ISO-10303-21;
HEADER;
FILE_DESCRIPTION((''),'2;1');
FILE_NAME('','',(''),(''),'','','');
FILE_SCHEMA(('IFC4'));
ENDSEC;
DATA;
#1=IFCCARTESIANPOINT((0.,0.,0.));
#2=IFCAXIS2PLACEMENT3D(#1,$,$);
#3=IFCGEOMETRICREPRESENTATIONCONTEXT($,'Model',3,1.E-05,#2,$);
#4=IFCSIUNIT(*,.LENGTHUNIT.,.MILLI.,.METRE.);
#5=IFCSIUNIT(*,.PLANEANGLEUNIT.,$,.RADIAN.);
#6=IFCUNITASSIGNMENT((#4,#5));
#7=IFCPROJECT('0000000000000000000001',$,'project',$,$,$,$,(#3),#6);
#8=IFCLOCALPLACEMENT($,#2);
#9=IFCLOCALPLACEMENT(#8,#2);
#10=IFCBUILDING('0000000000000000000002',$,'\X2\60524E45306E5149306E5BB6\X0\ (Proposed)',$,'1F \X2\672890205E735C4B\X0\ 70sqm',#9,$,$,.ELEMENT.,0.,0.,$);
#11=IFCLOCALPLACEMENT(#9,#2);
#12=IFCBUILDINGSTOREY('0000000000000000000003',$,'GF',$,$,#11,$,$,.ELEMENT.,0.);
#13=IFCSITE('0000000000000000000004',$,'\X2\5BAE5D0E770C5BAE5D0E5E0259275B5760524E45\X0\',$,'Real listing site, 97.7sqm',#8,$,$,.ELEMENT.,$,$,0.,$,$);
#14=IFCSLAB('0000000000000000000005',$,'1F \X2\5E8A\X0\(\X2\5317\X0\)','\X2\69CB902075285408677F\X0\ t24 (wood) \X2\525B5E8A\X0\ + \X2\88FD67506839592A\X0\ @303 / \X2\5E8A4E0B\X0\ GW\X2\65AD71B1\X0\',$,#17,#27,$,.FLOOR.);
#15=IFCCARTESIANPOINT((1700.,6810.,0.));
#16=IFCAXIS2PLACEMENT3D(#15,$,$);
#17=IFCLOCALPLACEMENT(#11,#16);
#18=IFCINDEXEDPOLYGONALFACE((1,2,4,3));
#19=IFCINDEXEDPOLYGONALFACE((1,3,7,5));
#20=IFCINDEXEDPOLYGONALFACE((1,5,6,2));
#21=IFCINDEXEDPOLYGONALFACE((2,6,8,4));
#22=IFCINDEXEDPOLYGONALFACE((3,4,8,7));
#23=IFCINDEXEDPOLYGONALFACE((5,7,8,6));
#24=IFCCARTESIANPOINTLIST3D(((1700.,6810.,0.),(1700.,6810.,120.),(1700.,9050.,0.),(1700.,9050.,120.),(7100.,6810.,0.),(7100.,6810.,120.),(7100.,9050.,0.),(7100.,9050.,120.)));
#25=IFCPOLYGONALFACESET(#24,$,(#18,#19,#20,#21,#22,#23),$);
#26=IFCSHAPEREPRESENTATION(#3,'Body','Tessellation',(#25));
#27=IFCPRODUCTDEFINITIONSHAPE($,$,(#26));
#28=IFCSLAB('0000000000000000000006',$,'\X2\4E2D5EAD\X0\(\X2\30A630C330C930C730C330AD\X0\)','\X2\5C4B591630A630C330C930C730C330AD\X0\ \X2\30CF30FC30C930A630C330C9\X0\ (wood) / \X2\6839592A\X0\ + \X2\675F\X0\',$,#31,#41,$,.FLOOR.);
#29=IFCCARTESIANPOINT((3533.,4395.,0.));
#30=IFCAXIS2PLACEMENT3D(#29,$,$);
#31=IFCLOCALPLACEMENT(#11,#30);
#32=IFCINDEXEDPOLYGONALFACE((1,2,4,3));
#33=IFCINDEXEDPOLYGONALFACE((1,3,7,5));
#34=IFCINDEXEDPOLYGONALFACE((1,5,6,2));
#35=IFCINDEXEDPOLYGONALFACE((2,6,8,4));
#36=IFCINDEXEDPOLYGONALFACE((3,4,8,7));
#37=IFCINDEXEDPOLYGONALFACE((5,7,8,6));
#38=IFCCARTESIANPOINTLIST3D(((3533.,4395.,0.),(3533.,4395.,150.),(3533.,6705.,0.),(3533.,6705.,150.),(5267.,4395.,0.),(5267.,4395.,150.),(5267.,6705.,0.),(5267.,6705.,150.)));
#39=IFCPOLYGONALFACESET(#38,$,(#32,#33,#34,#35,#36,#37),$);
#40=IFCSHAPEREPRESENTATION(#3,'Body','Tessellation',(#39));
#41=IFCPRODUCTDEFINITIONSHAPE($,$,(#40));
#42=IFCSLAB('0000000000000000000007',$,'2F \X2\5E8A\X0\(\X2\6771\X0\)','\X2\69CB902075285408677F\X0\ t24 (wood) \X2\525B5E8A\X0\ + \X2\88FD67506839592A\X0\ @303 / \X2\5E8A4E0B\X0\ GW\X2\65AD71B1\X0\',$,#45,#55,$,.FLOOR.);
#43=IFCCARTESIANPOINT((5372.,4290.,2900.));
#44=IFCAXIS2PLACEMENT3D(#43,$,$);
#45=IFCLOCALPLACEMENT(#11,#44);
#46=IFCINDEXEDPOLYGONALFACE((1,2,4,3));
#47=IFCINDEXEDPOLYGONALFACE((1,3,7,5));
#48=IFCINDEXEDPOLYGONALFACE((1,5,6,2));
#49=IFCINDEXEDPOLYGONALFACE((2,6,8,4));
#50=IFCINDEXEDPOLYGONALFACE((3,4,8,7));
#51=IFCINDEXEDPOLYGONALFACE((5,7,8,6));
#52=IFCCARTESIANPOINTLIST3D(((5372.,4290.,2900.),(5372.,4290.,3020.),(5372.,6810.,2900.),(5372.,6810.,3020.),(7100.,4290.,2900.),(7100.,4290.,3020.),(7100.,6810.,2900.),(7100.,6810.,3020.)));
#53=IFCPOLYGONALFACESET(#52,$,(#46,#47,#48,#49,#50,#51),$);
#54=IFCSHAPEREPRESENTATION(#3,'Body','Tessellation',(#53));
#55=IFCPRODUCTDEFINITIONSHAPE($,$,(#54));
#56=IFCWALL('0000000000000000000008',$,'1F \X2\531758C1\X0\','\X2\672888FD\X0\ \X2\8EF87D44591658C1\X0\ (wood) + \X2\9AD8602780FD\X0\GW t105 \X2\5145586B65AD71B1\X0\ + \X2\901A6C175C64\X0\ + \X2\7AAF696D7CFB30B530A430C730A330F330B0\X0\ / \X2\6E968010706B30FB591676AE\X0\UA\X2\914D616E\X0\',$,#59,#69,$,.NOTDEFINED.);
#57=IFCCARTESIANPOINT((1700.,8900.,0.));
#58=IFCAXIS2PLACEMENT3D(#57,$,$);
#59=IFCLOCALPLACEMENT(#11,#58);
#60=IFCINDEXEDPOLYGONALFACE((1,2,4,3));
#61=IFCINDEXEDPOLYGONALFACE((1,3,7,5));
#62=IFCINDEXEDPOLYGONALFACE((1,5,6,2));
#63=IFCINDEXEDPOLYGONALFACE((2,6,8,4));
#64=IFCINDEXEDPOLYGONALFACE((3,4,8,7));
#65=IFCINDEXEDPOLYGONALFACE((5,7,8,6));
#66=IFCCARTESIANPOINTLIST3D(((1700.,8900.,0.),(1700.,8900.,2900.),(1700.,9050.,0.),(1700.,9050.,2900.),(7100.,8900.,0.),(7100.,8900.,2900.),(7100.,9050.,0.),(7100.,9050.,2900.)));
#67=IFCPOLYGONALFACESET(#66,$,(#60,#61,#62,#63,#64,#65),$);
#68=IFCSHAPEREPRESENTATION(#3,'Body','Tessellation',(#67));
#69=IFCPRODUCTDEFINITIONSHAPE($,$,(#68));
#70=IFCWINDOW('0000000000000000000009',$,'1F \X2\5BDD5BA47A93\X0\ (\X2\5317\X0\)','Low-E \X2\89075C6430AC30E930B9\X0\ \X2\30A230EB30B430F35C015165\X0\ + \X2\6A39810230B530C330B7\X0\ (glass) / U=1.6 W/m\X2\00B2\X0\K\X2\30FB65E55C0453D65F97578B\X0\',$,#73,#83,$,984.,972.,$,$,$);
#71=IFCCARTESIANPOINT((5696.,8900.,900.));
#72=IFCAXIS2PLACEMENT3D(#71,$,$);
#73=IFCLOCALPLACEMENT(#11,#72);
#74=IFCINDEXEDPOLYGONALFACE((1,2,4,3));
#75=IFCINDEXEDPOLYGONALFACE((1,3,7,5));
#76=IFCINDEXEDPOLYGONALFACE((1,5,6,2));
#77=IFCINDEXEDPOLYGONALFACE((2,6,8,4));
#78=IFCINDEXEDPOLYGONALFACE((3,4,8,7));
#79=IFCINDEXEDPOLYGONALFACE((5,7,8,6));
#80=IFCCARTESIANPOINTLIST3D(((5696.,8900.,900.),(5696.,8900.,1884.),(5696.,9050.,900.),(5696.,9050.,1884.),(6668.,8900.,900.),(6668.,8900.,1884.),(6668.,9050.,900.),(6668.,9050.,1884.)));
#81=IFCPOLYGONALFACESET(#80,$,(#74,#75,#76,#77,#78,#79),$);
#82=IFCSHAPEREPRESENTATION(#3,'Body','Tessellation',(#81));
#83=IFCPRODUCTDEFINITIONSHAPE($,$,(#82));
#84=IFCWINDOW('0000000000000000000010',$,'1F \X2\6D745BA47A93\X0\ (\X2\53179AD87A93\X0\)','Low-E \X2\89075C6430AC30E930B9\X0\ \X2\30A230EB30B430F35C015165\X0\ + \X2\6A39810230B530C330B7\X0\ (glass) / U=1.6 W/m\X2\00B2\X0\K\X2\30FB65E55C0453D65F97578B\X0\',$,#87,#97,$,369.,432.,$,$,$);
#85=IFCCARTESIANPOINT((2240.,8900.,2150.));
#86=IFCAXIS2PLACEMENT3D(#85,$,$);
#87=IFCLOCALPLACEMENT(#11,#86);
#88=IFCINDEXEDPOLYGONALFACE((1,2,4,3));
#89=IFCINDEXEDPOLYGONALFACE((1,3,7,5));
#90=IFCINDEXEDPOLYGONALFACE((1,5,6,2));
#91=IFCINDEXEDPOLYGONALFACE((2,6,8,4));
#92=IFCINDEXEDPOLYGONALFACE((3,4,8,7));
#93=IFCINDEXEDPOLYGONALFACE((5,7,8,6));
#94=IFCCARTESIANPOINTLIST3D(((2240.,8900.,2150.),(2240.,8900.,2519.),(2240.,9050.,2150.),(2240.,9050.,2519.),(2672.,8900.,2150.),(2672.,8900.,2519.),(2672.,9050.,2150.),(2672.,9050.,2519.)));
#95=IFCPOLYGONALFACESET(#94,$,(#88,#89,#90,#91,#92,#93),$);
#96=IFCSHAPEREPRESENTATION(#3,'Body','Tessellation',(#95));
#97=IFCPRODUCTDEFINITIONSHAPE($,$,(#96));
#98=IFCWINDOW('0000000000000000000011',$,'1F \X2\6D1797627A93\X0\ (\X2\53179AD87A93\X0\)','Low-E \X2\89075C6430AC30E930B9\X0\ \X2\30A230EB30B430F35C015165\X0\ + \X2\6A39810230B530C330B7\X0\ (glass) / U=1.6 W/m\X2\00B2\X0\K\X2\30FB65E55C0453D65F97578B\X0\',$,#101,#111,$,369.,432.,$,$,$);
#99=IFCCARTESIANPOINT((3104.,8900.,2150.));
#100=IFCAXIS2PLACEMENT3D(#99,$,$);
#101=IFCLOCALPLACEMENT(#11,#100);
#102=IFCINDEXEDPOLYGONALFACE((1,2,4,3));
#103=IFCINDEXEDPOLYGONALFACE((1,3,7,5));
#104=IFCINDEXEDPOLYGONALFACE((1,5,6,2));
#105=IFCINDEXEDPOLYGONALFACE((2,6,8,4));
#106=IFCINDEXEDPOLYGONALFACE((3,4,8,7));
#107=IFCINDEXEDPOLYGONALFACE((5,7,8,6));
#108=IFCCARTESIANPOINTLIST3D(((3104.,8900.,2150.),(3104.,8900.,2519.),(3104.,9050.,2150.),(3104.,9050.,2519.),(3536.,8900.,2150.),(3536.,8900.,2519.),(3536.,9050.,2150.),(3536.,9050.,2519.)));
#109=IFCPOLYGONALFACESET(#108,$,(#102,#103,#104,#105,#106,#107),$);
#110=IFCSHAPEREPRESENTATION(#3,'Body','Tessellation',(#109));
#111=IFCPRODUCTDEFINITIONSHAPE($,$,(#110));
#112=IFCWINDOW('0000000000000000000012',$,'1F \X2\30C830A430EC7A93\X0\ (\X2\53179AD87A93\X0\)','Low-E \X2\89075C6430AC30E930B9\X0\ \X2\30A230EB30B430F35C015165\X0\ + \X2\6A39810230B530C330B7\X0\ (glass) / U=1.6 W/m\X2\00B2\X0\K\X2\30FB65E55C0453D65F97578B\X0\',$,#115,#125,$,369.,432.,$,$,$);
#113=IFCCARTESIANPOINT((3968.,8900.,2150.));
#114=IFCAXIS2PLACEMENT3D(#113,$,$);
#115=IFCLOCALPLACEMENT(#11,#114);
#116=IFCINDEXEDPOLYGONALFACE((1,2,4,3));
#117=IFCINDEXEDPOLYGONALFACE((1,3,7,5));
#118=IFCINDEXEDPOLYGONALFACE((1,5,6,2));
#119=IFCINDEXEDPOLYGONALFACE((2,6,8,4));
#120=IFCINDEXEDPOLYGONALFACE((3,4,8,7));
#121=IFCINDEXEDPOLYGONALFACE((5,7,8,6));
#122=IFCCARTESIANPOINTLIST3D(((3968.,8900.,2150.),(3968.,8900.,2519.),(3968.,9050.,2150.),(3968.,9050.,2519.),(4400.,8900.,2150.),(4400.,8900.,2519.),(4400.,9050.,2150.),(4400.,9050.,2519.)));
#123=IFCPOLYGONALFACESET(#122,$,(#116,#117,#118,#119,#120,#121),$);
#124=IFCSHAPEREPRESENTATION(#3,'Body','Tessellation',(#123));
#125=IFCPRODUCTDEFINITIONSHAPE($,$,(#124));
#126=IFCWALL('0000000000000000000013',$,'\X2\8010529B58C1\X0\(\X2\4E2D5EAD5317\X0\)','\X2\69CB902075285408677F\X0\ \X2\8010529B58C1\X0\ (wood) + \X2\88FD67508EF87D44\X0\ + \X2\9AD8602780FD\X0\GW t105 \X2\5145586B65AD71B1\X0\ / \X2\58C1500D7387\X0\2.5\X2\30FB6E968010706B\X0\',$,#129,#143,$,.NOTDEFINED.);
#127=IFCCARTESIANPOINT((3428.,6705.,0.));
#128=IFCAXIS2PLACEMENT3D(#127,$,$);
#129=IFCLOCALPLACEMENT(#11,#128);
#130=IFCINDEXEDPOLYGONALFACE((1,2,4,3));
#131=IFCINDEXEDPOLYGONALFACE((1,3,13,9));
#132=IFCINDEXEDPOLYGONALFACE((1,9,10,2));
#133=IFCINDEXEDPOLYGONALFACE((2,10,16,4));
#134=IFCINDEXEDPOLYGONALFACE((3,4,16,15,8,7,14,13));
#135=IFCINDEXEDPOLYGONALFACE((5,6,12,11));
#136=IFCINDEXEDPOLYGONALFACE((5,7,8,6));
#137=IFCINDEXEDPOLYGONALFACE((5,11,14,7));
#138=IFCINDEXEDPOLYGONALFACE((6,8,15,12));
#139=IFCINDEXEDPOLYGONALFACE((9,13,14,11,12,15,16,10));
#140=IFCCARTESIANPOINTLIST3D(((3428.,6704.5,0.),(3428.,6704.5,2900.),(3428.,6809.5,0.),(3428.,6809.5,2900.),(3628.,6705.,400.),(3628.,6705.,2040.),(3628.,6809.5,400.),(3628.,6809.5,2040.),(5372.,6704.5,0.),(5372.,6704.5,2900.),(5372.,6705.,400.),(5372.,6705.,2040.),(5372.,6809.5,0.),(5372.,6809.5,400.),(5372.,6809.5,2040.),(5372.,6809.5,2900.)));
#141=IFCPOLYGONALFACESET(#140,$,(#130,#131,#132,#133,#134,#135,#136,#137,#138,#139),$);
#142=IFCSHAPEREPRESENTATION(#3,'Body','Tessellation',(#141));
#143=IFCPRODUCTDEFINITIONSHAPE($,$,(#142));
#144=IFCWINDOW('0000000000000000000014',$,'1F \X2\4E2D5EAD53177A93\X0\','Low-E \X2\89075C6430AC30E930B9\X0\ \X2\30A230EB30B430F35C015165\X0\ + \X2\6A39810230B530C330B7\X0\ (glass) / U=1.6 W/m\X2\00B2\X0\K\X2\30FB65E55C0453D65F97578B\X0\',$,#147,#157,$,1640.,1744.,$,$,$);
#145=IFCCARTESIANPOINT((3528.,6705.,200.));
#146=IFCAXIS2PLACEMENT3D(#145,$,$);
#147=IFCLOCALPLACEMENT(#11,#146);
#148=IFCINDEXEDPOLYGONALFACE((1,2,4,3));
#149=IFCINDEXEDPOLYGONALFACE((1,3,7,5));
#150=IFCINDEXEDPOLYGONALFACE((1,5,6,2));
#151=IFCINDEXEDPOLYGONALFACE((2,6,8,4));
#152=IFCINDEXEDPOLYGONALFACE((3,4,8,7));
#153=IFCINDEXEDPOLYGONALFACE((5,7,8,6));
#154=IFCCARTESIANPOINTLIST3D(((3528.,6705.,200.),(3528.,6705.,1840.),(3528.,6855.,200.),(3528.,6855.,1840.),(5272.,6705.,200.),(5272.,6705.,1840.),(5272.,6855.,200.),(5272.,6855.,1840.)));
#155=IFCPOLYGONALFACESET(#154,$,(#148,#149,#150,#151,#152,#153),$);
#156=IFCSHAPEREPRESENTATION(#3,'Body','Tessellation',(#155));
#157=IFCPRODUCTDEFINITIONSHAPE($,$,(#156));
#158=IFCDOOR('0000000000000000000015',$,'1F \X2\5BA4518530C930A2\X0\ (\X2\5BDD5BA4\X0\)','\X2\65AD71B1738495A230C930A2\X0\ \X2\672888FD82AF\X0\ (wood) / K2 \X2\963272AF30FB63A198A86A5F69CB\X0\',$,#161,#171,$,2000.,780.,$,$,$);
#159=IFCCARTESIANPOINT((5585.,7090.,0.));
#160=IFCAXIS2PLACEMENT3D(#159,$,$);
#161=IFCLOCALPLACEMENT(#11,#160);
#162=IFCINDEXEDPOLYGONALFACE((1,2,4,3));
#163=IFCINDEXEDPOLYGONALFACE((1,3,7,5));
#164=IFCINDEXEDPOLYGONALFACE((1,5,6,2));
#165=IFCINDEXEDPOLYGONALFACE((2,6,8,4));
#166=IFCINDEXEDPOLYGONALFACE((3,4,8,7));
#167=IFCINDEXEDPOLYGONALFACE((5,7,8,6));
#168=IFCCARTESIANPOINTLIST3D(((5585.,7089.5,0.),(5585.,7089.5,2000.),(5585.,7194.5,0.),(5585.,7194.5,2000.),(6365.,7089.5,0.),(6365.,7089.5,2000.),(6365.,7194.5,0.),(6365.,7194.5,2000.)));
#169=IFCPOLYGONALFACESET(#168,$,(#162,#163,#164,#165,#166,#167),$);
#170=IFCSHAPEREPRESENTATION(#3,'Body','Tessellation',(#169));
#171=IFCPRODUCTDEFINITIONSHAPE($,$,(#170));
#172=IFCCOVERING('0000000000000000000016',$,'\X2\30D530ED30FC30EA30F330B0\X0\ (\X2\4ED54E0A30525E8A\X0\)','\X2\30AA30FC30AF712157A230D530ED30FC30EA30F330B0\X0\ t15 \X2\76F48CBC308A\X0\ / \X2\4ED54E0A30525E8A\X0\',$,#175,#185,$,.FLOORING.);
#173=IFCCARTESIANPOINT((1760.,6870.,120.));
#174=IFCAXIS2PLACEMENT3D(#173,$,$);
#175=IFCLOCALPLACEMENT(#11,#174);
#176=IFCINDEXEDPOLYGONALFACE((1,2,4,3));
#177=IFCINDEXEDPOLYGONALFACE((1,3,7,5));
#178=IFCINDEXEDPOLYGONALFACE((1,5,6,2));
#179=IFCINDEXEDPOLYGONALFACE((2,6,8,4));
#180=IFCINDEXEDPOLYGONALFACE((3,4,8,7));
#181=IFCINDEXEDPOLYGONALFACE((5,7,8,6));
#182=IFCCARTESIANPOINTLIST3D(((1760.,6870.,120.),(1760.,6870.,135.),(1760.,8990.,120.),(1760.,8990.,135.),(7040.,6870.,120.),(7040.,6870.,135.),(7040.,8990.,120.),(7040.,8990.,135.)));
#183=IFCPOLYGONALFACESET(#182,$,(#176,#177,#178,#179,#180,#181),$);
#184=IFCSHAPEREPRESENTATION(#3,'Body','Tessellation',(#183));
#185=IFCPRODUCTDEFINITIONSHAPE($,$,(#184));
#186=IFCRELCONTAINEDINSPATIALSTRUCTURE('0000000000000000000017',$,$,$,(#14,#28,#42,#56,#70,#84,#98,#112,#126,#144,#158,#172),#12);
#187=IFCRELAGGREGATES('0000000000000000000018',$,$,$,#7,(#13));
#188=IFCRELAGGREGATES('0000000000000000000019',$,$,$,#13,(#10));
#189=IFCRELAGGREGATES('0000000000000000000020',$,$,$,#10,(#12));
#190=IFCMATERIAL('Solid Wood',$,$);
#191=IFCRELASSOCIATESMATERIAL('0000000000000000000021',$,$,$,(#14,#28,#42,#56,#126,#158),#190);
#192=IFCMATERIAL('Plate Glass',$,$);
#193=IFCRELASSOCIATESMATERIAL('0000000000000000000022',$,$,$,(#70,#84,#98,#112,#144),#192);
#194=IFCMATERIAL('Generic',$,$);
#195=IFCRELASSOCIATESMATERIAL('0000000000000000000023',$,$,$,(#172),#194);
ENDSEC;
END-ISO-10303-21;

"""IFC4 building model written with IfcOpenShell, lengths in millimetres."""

from ifc_helpers import new_model, si_unit, frame, frame_2d, origin, place, context, project, spatial, rectangle, extrude, material, element, fill, save


model = new_model("IFC4")

# Units and contexts
model_context = context("Model", 3, precision=1e-05, world=origin())
ifc_project = project(units=[si_unit("LENGTHUNIT", "METRE", prefix="MILLI"), si_unit("PLANEANGLEUNIT", "RADIAN")], contexts=[model_context])

# Site, building, storey
site_placement = place(None, origin())
site = spatial("IfcSite", under=ifc_project, at=site_placement, Name="宮崎県宮崎市大字恒久", ObjectType="Real listing site, 97.7sqm", CompositionType="ELEMENT", RefElevation=0.0)
building_placement = place(site_placement, origin())
building = spatial("IfcBuilding", under=site, at=building_placement, Name="恒久の光の家 (Proposed)", ObjectType="1F 木造平屋 70sqm", CompositionType="ELEMENT", ElevationOfRefHeight=0.0, ElevationOfTerrain=0.0)
storey_placement = place(building_placement, origin())
storey = spatial("IfcBuildingStorey", under=building, at=storey_placement, Name="GF", CompositionType="ELEMENT", Elevation=0.0)

# Slabs
ifc_material_1 = material(Name="Solid Wood")
slab_1_placement = place(storey_placement, frame((1700.0, 6810.0, 0.0)))
element("IfcSlab", 1, at=slab_1_placement, inside=storey, material=ifc_material_1, Name="1F 床(北)", Description="構造用合板 t24 (wood) 剛床 + 製材根太 @303 / 床下 GW断熱", PredefinedType="FLOOR", context=model_context, shape_type="SweptSolid", body=[
    extrude(rectangle(XDim=5400.0, YDim=2240.0, at=frame_2d((2700.0, 1120.0))), frame((1700.0, 6810.0, 0.0)), (0.0, 0.0, 1.0), 120.0),
])
slab_2_placement = place(storey_placement, frame((3533.0, 4395.0, 0.0)))
element("IfcSlab", 2, at=slab_2_placement, inside=storey, material=ifc_material_1, Name="中庭(ウッドデッキ)", Description="屋外ウッドデッキ ハードウッド (wood) / 根太 + 束", PredefinedType="FLOOR", context=model_context, shape_type="SweptSolid", body=[
    extrude(rectangle(XDim=1734.0, YDim=2310.0, at=frame_2d((867.0, 1155.0))), frame((3533.0, 4395.0, 0.0)), (0.0, 0.0, 1.0), 150.0),
])
slab_3_placement = place(storey_placement, frame((5372.0, 4290.0, 2900.0)))
element("IfcSlab", 3, at=slab_3_placement, inside=storey, material=ifc_material_1, Name="2F 床(東)", Description="構造用合板 t24 (wood) 剛床 + 製材根太 @303 / 床下 GW断熱", PredefinedType="FLOOR", context=model_context, shape_type="SweptSolid", body=[
    extrude(rectangle(XDim=1728.0, YDim=2520.0, at=frame_2d((864.0, 1260.0))), frame((5372.0, 4290.0, 2900.0)), (0.0, 0.0, 1.0), 120.0),
])

# Wall, openings, windows
wall_1_placement = place(storey_placement, frame((1700.0, 8900.0, 0.0)))
wall_1 = element("IfcWall", 4, at=wall_1_placement, inside=storey, material=ifc_material_1, Name="1F 北壁", Description="木製 軸組外壁 (wood) + 高性能GW t105 充填断熱 + 通気層 + 窯業系サイディング / 準耐火・外皮UA配慮", PredefinedType="NOTDEFINED", context=model_context, shape_type="SweptSolid", body=[
    extrude(rectangle(XDim=5400.0, YDim=150.0, at=frame_2d((2700.0, 75.0))), frame((1700.0, 8900.0, 0.0)), (0.0, 0.0, 1.0), 2900.0),
])
opening_1_placement = place(storey_placement, frame((5696.0, 8900.0, 900.0)))
opening_1 = element("IfcOpeningElement", 5, at=opening_1_placement, cuts=wall_1, PredefinedType="NOTDEFINED", context=model_context, shape_type="SweptSolid", body=[
    extrude(rectangle(XDim=972.0, YDim=150.0, at=frame_2d((486.0, 75.0))), frame((5696.0, 8900.0, 900.0)), (0.0, 0.0, 1.0), 984.0),
])
opening_2_placement = place(storey_placement, frame((2240.0, 8900.0, 2150.0)))
opening_2 = element("IfcOpeningElement", 6, at=opening_2_placement, cuts=wall_1, PredefinedType="NOTDEFINED", context=model_context, shape_type="SweptSolid", body=[
    extrude(rectangle(XDim=432.0, YDim=150.0, at=frame_2d((216.0, 75.0))), frame((2240.0, 8900.0, 2150.0)), (0.0, 0.0, 1.0), 369.0),
])
opening_3_placement = place(storey_placement, frame((3104.0, 8900.0, 2150.0)))
opening_3 = element("IfcOpeningElement", 7, at=opening_3_placement, cuts=wall_1, PredefinedType="NOTDEFINED", context=model_context, shape_type="SweptSolid", body=[
    extrude(rectangle(XDim=432.0, YDim=150.0, at=frame_2d((216.0, 75.0))), frame((3104.0, 8900.0, 2150.0)), (0.0, 0.0, 1.0), 369.0),
])
opening_4_placement = place(storey_placement, frame((3968.0, 8900.0, 2150.0)))
opening_4 = element("IfcOpeningElement", 8, at=opening_4_placement, cuts=wall_1, PredefinedType="NOTDEFINED", context=model_context, shape_type="SweptSolid", body=[
    extrude(rectangle(XDim=432.0, YDim=150.0, at=frame_2d((216.0, 75.0))), frame((3968.0, 8900.0, 2150.0)), (0.0, 0.0, 1.0), 369.0),
])
ifc_material_2 = material(Name="Plate Glass")
window_1_placement = place(storey_placement, frame((5696.0, 8900.0, 900.0)))
window_1 = element("IfcWindow", 9, at=window_1_placement, inside=storey, material=ifc_material_2, Name="1F 寝室窓 (北)", Description="Low-E 複層ガラス アルゴン封入 + 樹脂サッシ (glass) / U=1.6 W/m²K・日射取得型", OverallHeight=984.0, OverallWidth=972.0, context=model_context, shape_type="SweptSolid", body=[
    extrude(rectangle(XDim=972.0, YDim=150.0, at=frame_2d((486.0, 75.0))), frame((5696.0, 8900.0, 900.0)), (0.0, 0.0, 1.0), 984.0),
])
fill(opening_1, window_1)
window_2_placement = place(storey_placement, frame((2240.0, 8900.0, 2150.0)))
window_2 = element("IfcWindow", 10, at=window_2_placement, inside=storey, material=ifc_material_2, Name="1F 浴室窓 (北高窓)", Description="Low-E 複層ガラス アルゴン封入 + 樹脂サッシ (glass) / U=1.6 W/m²K・日射取得型", OverallHeight=369.0, OverallWidth=432.0, context=model_context, shape_type="SweptSolid", body=[
    extrude(rectangle(XDim=432.0, YDim=150.0, at=frame_2d((216.0, 75.0))), frame((2240.0, 8900.0, 2150.0)), (0.0, 0.0, 1.0), 369.0),
])
fill(opening_2, window_2)
window_3_placement = place(storey_placement, frame((3104.0, 8900.0, 2150.0)))
window_3 = element("IfcWindow", 11, at=window_3_placement, inside=storey, material=ifc_material_2, Name="1F 洗面窓 (北高窓)", Description="Low-E 複層ガラス アルゴン封入 + 樹脂サッシ (glass) / U=1.6 W/m²K・日射取得型", OverallHeight=369.0, OverallWidth=432.0, context=model_context, shape_type="SweptSolid", body=[
    extrude(rectangle(XDim=432.0, YDim=150.0, at=frame_2d((216.0, 75.0))), frame((3104.0, 8900.0, 2150.0)), (0.0, 0.0, 1.0), 369.0),
])
fill(opening_3, window_3)
window_4_placement = place(storey_placement, frame((3968.0, 8900.0, 2150.0)))
window_4 = element("IfcWindow", 12, at=window_4_placement, inside=storey, material=ifc_material_2, Name="1F トイレ窓 (北高窓)", Description="Low-E 複層ガラス アルゴン封入 + 樹脂サッシ (glass) / U=1.6 W/m²K・日射取得型", OverallHeight=369.0, OverallWidth=432.0, context=model_context, shape_type="SweptSolid", body=[
    extrude(rectangle(XDim=432.0, YDim=150.0, at=frame_2d((216.0, 75.0))), frame((3968.0, 8900.0, 2150.0)), (0.0, 0.0, 1.0), 369.0),
])
fill(opening_4, window_4)

# Wall, opening, window
wall_2_placement = place(storey_placement, frame((3428.0, 6705.0, 0.0)))
wall_2 = element("IfcWall", 13, at=wall_2_placement, inside=storey, material=ifc_material_1, Name="耐力壁(中庭北)", Description="構造用合板 耐力壁 (wood) + 製材軸組 + 高性能GW t105 充填断熱 / 壁倍率2.5・準耐火", PredefinedType="NOTDEFINED", context=model_context, shape_type="SweptSolid", body=[
    extrude(rectangle(XDim=1944.0, YDim=105.0, at=frame_2d((972.0, 52.0))), frame((3428.0, 6705.0, 0.0)), (0.0, 0.0, 1.0), 2900.0),
])
opening_5_placement = place(storey_placement, frame((3528.0, 6705.0, 200.0)))
opening_5 = element("IfcOpeningElement", 14, at=opening_5_placement, cuts=wall_2, PredefinedType="NOTDEFINED", context=model_context, shape_type="SweptSolid", body=[
    extrude(rectangle(XDim=1744.0, YDim=150.0, at=frame_2d((872.0, 75.0))), frame((3528.0, 6705.0, 200.0)), (0.0, 0.0, 1.0), 1640.0),
])
window_5_placement = place(storey_placement, frame((3528.0, 6705.0, 200.0)))
window_5 = element("IfcWindow", 15, at=window_5_placement, inside=storey, material=ifc_material_2, Name="1F 中庭北窓", Description="Low-E 複層ガラス アルゴン封入 + 樹脂サッシ (glass) / U=1.6 W/m²K・日射取得型", OverallHeight=1640.0, OverallWidth=1744.0, context=model_context, shape_type="SweptSolid", body=[
    extrude(rectangle(XDim=1744.0, YDim=150.0, at=frame_2d((872.0, 75.0))), frame((3528.0, 6705.0, 200.0)), (0.0, 0.0, 1.0), 1640.0),
])
fill(opening_5, window_5)

# Door
door_1_placement = place(storey_placement, frame((5585.0, 7090.0, 0.0)))
element("IfcDoor", 16, at=door_1_placement, inside=storey, material=ifc_material_1, Name="1F 室内ドア (寝室)", Description="断熱玄関ドア 木製芯 (wood) / K2 防犯・採風機構", OverallHeight=2000.0, OverallWidth=780.0, context=model_context, shape_type="SweptSolid", body=[
    extrude(rectangle(XDim=780.0, YDim=105.0, at=frame_2d((390.0, 52.0))), frame((5585.0, 7090.0, 0.0)), (0.0, 0.0, 1.0), 2000.0),
])

# Covering
ifc_material_3 = material(Name="Generic")
covering_1_placement = place(storey_placement, frame((1760.0, 6870.0, 120.0)))
element("IfcCovering", 17, at=covering_1_placement, inside=storey, material=ifc_material_3, Name="フローリング (仕上げ床)", Description="オーク無垢フローリング t15 直貼り / 仕上げ床", PredefinedType="FLOORING", context=model_context, shape_type="SweptSolid", body=[
    extrude(rectangle(XDim=5280.0, YDim=2120.0, at=frame_2d((2640.0, 1060.0))), frame((1760.0, 6870.0, 120.0)), (0.0, 0.0, 1.0), 15.0),
])

save(model, "model.ifc")
